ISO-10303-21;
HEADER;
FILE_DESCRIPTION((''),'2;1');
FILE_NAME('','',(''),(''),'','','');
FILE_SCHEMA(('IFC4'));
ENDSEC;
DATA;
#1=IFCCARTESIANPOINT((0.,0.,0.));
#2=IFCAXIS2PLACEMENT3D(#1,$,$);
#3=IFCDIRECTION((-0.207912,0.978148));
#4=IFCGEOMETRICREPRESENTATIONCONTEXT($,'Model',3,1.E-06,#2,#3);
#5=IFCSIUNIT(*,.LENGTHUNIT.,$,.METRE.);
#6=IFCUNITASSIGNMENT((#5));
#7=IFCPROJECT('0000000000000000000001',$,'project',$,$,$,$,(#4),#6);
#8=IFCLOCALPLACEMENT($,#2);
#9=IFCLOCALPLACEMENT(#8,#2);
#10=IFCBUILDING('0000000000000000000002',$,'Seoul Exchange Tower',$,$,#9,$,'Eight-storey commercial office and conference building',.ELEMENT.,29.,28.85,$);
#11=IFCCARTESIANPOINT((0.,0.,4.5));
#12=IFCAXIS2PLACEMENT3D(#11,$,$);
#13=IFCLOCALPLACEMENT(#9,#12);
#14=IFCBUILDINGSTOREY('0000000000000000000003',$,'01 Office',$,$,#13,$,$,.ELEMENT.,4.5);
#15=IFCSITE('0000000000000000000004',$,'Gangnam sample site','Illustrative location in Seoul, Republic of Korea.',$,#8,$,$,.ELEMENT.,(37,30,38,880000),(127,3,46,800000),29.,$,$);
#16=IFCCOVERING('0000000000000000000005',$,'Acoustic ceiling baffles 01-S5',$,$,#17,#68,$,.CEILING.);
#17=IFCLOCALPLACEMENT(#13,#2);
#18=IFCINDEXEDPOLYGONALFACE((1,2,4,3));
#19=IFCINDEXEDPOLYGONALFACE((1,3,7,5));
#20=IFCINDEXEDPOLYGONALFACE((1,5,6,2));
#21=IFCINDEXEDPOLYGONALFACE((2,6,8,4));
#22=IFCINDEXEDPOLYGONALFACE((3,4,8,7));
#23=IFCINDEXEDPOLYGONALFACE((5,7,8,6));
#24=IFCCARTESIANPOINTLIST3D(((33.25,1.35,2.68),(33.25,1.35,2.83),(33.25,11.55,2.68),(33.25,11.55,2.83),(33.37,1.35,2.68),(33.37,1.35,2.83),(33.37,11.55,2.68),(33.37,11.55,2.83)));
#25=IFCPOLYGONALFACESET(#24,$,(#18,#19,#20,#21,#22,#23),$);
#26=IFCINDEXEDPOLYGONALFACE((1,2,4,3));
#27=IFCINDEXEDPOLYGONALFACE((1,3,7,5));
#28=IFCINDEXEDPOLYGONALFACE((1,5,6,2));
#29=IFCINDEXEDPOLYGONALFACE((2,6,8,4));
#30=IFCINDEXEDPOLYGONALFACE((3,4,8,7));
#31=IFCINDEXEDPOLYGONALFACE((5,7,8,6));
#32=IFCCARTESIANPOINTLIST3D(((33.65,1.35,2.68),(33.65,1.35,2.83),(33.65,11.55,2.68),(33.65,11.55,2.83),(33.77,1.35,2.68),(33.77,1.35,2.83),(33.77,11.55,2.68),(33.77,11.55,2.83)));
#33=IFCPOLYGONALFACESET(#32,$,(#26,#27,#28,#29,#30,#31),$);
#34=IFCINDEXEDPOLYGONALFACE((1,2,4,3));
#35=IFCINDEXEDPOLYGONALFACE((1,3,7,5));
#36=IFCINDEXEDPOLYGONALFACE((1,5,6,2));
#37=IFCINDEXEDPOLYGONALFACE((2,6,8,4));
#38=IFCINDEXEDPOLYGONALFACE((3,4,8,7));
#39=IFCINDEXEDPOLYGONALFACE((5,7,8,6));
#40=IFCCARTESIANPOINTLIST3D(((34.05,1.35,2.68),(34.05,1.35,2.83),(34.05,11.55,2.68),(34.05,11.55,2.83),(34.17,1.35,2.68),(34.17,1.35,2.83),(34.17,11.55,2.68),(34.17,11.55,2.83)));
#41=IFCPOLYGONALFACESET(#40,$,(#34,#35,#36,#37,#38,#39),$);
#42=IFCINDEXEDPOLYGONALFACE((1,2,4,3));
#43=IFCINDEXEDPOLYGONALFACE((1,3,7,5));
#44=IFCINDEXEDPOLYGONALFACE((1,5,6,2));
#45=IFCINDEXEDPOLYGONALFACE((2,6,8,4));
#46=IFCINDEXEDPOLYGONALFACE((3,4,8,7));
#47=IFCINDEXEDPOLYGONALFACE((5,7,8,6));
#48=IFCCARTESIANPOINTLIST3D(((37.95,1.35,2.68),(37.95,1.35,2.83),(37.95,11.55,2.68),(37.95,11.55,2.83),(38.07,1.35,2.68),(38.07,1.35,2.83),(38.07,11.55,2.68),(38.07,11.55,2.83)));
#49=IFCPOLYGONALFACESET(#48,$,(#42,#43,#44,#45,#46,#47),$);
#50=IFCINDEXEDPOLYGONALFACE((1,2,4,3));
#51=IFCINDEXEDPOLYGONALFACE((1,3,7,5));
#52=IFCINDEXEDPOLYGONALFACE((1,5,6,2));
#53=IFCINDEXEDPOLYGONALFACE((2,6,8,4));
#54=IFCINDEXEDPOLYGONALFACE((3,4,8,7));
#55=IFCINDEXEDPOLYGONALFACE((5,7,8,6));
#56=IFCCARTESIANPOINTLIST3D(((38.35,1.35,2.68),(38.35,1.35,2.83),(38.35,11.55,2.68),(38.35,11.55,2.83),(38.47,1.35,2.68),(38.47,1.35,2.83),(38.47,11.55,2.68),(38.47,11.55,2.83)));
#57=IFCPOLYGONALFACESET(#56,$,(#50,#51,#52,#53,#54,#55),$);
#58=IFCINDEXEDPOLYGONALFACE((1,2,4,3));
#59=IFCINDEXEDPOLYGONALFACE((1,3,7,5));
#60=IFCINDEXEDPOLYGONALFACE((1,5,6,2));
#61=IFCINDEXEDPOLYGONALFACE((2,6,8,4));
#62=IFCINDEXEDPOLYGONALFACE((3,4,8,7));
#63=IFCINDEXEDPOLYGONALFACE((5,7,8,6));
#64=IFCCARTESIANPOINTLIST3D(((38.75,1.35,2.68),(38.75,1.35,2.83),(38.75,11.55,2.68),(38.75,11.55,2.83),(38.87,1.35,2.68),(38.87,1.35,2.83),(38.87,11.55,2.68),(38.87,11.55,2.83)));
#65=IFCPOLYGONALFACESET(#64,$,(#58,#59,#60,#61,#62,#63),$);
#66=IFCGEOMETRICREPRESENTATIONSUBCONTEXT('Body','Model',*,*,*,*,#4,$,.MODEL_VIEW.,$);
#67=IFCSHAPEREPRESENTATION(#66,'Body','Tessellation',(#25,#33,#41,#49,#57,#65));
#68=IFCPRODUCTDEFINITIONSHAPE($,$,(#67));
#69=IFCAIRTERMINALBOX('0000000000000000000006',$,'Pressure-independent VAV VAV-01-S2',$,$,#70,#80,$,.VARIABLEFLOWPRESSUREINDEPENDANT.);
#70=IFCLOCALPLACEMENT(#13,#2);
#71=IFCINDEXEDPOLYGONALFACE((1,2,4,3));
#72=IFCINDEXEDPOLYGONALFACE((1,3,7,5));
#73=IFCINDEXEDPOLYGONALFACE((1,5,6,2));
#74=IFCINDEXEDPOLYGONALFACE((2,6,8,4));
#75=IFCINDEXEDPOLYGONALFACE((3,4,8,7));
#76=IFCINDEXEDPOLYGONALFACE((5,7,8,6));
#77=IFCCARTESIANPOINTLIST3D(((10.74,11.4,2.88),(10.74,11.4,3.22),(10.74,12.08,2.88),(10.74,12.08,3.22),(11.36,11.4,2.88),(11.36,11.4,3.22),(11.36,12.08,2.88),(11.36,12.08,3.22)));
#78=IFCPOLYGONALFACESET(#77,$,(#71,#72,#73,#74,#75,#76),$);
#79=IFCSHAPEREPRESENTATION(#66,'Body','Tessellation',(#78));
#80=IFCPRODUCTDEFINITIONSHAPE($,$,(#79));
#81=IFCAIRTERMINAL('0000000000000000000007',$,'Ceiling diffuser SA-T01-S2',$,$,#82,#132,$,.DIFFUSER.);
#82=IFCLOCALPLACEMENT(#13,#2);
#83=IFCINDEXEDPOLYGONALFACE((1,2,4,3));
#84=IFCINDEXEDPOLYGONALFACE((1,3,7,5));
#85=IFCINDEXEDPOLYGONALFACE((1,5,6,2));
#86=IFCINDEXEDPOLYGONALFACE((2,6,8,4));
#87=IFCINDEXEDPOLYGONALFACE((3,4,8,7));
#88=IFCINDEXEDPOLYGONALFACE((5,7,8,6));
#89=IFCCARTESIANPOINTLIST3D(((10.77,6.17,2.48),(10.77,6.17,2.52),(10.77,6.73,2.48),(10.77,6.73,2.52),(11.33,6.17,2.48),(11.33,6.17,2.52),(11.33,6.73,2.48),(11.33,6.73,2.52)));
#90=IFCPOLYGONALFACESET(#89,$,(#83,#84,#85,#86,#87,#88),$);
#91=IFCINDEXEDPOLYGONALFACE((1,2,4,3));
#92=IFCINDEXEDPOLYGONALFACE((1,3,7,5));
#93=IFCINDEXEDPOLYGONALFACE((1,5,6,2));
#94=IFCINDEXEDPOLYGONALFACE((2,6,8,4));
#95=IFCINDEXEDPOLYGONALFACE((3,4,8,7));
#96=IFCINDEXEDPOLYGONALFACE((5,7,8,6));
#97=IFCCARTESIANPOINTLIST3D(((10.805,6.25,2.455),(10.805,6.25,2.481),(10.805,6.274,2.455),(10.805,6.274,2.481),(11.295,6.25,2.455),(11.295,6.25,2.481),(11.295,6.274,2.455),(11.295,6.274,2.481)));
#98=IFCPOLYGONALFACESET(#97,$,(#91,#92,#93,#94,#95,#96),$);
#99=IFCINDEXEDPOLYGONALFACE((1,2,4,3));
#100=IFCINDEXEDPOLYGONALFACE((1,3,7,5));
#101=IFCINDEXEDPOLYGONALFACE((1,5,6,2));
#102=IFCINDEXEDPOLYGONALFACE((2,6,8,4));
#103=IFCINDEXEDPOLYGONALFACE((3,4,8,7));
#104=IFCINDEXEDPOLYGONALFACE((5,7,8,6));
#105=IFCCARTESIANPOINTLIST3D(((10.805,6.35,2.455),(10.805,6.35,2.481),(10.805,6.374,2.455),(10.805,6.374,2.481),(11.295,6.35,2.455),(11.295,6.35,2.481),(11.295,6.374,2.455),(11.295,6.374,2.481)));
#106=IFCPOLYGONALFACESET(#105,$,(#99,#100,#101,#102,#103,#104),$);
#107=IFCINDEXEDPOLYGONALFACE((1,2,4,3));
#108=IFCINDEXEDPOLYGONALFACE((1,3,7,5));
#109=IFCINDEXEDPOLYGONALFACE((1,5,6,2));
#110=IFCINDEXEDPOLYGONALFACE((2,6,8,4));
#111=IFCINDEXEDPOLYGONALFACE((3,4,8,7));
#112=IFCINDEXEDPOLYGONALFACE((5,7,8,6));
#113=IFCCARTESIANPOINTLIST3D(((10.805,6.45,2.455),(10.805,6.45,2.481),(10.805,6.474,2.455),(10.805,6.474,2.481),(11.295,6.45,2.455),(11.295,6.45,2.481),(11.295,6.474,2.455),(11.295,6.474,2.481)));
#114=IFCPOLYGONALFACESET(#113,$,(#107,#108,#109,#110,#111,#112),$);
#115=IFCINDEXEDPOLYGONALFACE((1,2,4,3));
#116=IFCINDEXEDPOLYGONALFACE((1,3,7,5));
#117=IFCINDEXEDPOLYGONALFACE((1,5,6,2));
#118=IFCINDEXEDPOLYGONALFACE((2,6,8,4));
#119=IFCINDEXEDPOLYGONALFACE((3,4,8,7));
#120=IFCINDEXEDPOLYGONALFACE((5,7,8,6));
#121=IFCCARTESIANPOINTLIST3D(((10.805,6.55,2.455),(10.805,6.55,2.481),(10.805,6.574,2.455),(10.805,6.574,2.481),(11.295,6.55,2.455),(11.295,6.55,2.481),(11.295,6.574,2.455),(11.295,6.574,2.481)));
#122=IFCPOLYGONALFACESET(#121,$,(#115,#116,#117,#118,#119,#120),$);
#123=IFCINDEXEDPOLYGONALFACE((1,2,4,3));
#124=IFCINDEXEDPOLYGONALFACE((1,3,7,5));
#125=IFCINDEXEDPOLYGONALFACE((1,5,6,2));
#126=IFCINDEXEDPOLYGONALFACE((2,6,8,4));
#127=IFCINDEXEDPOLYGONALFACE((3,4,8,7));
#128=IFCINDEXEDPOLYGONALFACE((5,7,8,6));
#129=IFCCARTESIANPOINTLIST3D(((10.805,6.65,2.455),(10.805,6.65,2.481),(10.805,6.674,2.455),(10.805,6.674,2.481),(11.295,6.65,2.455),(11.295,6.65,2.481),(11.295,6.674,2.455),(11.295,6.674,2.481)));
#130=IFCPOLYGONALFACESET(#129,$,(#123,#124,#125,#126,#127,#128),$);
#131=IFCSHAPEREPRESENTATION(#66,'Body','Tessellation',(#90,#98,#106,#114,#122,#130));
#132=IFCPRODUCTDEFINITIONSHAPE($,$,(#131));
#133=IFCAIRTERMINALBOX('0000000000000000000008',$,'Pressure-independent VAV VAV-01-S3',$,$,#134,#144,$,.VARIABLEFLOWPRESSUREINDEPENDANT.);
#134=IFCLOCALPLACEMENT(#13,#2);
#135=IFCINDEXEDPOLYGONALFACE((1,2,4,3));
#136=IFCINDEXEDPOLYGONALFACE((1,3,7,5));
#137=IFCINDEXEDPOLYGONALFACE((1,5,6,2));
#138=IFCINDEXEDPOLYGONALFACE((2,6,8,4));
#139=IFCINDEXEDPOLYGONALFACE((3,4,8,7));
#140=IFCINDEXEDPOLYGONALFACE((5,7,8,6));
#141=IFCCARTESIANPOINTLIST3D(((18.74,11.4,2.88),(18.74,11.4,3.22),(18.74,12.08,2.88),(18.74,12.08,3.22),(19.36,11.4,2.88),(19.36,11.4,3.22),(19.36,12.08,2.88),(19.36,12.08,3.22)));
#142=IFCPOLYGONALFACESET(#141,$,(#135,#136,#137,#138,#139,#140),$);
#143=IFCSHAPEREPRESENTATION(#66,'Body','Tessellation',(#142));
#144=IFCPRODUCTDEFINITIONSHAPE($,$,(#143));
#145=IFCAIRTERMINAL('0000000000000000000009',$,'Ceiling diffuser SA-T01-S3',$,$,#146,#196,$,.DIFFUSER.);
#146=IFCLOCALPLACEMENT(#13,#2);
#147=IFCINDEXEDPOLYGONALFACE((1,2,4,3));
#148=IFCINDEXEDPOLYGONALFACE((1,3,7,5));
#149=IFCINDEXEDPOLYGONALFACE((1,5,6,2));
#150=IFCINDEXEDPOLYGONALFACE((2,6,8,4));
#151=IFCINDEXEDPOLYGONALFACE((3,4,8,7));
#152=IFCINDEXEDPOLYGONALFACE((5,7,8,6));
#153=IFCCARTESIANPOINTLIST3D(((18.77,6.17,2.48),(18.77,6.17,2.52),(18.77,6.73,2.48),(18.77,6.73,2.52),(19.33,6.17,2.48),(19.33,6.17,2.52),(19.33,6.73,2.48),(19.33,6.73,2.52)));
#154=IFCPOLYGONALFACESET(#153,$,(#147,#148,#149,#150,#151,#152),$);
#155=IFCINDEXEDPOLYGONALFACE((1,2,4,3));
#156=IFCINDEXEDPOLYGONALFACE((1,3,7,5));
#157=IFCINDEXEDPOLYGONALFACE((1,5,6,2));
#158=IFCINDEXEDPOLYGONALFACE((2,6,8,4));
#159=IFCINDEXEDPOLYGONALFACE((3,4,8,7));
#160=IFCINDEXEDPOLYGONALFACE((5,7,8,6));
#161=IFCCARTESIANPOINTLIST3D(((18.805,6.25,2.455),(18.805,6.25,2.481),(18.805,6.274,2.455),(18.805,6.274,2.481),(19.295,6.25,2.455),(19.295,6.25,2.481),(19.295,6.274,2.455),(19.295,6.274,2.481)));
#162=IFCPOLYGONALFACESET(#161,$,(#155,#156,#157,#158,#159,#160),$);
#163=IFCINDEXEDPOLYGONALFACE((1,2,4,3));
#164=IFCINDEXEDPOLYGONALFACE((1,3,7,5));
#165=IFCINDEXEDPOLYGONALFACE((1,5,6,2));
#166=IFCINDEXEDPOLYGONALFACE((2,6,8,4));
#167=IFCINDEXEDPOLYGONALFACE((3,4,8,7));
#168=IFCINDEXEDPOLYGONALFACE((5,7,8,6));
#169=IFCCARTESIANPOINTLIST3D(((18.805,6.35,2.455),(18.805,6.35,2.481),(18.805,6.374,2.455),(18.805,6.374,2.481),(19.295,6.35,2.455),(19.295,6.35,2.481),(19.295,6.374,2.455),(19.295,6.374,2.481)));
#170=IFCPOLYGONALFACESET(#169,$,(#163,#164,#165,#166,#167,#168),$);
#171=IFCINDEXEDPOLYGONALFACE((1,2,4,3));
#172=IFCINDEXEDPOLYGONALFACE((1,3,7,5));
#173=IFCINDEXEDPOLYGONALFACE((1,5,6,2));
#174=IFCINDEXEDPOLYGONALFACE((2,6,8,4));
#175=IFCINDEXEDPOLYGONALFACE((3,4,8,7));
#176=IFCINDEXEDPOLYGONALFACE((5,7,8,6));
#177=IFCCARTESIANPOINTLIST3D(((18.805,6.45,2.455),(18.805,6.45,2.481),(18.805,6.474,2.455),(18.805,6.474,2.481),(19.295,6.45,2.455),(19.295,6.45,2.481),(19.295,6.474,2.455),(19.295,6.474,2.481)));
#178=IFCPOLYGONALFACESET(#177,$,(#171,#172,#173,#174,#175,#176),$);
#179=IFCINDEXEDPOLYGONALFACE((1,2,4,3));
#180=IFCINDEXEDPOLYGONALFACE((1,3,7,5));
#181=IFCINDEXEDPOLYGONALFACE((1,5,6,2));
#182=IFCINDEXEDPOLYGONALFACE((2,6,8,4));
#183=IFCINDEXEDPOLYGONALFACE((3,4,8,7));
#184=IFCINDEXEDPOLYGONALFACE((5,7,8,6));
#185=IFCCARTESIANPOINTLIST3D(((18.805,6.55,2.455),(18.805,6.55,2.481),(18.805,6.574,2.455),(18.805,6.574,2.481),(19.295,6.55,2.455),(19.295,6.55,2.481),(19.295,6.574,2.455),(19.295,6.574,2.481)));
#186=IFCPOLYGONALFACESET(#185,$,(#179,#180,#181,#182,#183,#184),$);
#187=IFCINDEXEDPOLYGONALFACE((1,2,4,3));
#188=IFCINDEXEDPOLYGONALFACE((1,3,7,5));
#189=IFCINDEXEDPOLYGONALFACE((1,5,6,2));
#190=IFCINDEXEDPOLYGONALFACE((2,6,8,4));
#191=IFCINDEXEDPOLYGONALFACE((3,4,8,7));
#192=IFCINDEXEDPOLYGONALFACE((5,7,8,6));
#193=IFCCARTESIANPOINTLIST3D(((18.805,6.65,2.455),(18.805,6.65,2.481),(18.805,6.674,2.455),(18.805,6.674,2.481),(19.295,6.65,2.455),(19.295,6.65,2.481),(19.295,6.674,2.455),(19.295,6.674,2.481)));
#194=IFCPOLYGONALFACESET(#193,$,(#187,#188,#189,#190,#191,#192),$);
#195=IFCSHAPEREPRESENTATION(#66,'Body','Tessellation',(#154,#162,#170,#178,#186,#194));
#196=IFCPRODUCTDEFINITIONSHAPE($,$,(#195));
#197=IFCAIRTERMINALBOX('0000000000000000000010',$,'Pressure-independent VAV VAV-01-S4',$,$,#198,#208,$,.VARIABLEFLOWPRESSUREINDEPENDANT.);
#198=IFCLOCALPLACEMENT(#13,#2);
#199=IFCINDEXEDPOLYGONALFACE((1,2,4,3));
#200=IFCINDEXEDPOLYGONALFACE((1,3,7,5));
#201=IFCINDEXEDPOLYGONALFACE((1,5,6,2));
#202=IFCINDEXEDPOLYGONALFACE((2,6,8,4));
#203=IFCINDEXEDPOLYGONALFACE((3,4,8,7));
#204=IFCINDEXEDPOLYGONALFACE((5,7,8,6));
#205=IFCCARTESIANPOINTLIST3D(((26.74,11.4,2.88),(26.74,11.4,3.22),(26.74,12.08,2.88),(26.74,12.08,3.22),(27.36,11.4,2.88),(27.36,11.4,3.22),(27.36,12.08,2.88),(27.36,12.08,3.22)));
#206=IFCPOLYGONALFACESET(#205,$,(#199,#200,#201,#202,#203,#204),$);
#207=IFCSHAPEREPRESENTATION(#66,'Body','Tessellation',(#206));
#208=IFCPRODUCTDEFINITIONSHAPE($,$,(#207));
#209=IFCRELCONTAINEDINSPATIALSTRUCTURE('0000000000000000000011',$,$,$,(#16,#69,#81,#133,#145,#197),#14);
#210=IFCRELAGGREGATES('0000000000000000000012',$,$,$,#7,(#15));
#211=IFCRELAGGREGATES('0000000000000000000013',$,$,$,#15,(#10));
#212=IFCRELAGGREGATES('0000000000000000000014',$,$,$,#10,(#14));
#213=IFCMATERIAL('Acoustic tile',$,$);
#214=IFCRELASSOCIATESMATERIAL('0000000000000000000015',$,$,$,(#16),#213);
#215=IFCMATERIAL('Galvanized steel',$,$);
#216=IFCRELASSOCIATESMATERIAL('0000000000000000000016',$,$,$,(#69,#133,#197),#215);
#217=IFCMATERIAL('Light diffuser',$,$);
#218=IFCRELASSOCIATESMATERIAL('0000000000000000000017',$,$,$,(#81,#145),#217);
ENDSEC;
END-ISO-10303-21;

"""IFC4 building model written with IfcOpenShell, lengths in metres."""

from ifc_helpers import new_model, si_unit, direction, frame, frame_2d, origin, place, context, subcontext, project, spatial, rectangle, extrude, material, element, save


model = new_model("IFC4")

# Units and contexts
model_context = context("Model", 3, precision=1e-06, world=origin(), true_north=direction((-0.207912, 0.978148)))
body_context = subcontext(model_context, "Body", "Model", "MODEL_VIEW")
ifc_project = project(units=[si_unit("LENGTHUNIT", "METRE")], contexts=[model_context])

# Site, building, storey
site_placement = place(None, origin())
site = spatial("IfcSite", under=ifc_project, at=site_placement, Name="Gangnam sample site", Description="Illustrative location in Seoul, Republic of Korea.", CompositionType="ELEMENT", RefLatitude=(37, 30, 38, 880000), RefLongitude=(127, 3, 46, 800000), RefElevation=29.0)
building_placement = place(site_placement, origin())
building = spatial("IfcBuilding", under=site, at=building_placement, Name="Seoul Exchange Tower", LongName="Eight-storey commercial office and conference building", CompositionType="ELEMENT", ElevationOfRefHeight=29.0, ElevationOfTerrain=28.85)
storey_placement = place(building_placement, frame((0.0, 0.0, 4.5)))
storey = spatial("IfcBuildingStorey", under=building, at=storey_placement, Name="01 Office", CompositionType="ELEMENT", Elevation=4.5)

# Covering
ifc_material_1 = material(Name="Acoustic tile")
placement = place(storey_placement, origin())
element("IfcCovering", 1, at=placement, inside=storey, material=ifc_material_1, Name="Acoustic ceiling baffles 01-S5", PredefinedType="CEILING", context=body_context, shape_type="SweptSolid", body=[
    extrude(rectangle(XDim=0.12, YDim=10.2, at=frame_2d((0.06, 5.1))), frame((33.25, 1.35, 2.68)), (0.0, 0.0, 1.0), 0.15),
    extrude(rectangle(XDim=0.12, YDim=10.2, at=frame_2d((0.06, 5.1))), frame((33.65, 1.35, 2.68)), (0.0, 0.0, 1.0), 0.15),
    extrude(rectangle(XDim=0.12, YDim=10.2, at=frame_2d((0.06, 5.1))), frame((34.05, 1.35, 2.68)), (0.0, 0.0, 1.0), 0.15),
    extrude(rectangle(XDim=0.12, YDim=10.2, at=frame_2d((0.06, 5.1))), frame((37.95, 1.35, 2.68)), (0.0, 0.0, 1.0), 0.15),
    extrude(rectangle(XDim=0.12, YDim=10.2, at=frame_2d((0.06, 5.1))), frame((38.35, 1.35, 2.68)), (0.0, 0.0, 1.0), 0.15),
    extrude(rectangle(XDim=0.12, YDim=10.2, at=frame_2d((0.06, 5.1))), frame((38.75, 1.35, 2.68)), (0.0, 0.0, 1.0), 0.15),
])

# Air terminal box
ifc_material_2 = material(Name="Galvanized steel")
element("IfcAirTerminalBox", 2, at=placement, inside=storey, material=ifc_material_2, Name="Pressure-independent VAV VAV-01-S2", PredefinedType="VARIABLEFLOWPRESSUREINDEPENDANT", context=body_context, shape_type="SweptSolid", body=[
    extrude(rectangle(XDim=0.62, YDim=0.68, at=frame_2d((0.31, 0.34))), frame((10.74, 11.4, 2.88)), (0.0, 0.0, 1.0), 0.34),
])

# Air terminal
ifc_material_3 = material(Name="Light diffuser")
element("IfcAirTerminal", 3, at=placement, inside=storey, material=ifc_material_3, Name="Ceiling diffuser SA-T01-S2", PredefinedType="DIFFUSER", context=body_context, shape_type="SweptSolid", body=[
    extrude(rectangle(XDim=0.56, YDim=0.56, at=frame_2d((0.28, 0.28))), frame((10.77, 6.17, 2.48)), (0.0, 0.0, 1.0), 0.04),
    extrude(rectangle(XDim=0.49, YDim=0.024, at=frame_2d((0.245, 0.012))), frame((10.805, 6.25, 2.455)), (0.0, 0.0, 1.0), 0.026),
    extrude(rectangle(XDim=0.49, YDim=0.024, at=frame_2d((0.245, 0.012))), frame((10.805, 6.35, 2.455)), (0.0, 0.0, 1.0), 0.026),
    extrude(rectangle(XDim=0.49, YDim=0.024, at=frame_2d((0.245, 0.012))), frame((10.805, 6.45, 2.455)), (0.0, 0.0, 1.0), 0.026),
    extrude(rectangle(XDim=0.49, YDim=0.024, at=frame_2d((0.245, 0.012))), frame((10.805, 6.55, 2.455)), (0.0, 0.0, 1.0), 0.026),
    extrude(rectangle(XDim=0.49, YDim=0.024, at=frame_2d((0.245, 0.012))), frame((10.805, 6.65, 2.455)), (0.0, 0.0, 1.0), 0.026),
])

# Air terminal box
element("IfcAirTerminalBox", 4, at=placement, inside=storey, material=ifc_material_2, Name="Pressure-independent VAV VAV-01-S3", PredefinedType="VARIABLEFLOWPRESSUREINDEPENDANT", context=body_context, shape_type="SweptSolid", body=[
    extrude(rectangle(XDim=0.62, YDim=0.68, at=frame_2d((0.31, 0.34))), frame((18.74, 11.4, 2.88)), (0.0, 0.0, 1.0), 0.34),
])

# Air terminal
element("IfcAirTerminal", 5, at=placement, inside=storey, material=ifc_material_3, Name="Ceiling diffuser SA-T01-S3", PredefinedType="DIFFUSER", context=body_context, shape_type="SweptSolid", body=[
    extrude(rectangle(XDim=0.56, YDim=0.56, at=frame_2d((0.28, 0.28))), frame((18.77, 6.17, 2.48)), (0.0, 0.0, 1.0), 0.04),
    extrude(rectangle(XDim=0.49, YDim=0.024, at=frame_2d((0.245, 0.012))), frame((18.805, 6.25, 2.455)), (0.0, 0.0, 1.0), 0.026),
    extrude(rectangle(XDim=0.49, YDim=0.024, at=frame_2d((0.245, 0.012))), frame((18.805, 6.35, 2.455)), (0.0, 0.0, 1.0), 0.026),
    extrude(rectangle(XDim=0.49, YDim=0.024, at=frame_2d((0.245, 0.012))), frame((18.805, 6.45, 2.455)), (0.0, 0.0, 1.0), 0.026),
    extrude(rectangle(XDim=0.49, YDim=0.024, at=frame_2d((0.245, 0.012))), frame((18.805, 6.55, 2.455)), (0.0, 0.0, 1.0), 0.026),
    extrude(rectangle(XDim=0.49, YDim=0.024, at=frame_2d((0.245, 0.012))), frame((18.805, 6.65, 2.455)), (0.0, 0.0, 1.0), 0.026),
])

# Air terminal box
element("IfcAirTerminalBox", 6, at=placement, inside=storey, material=ifc_material_2, Name="Pressure-independent VAV VAV-01-S4", PredefinedType="VARIABLEFLOWPRESSUREINDEPENDANT", context=body_context, shape_type="SweptSolid", body=[
    extrude(rectangle(XDim=0.62, YDim=0.68, at=frame_2d((0.31, 0.34))), frame((26.74, 11.4, 2.88)), (0.0, 0.0, 1.0), 0.34),
])

save(model, "model.ifc")
